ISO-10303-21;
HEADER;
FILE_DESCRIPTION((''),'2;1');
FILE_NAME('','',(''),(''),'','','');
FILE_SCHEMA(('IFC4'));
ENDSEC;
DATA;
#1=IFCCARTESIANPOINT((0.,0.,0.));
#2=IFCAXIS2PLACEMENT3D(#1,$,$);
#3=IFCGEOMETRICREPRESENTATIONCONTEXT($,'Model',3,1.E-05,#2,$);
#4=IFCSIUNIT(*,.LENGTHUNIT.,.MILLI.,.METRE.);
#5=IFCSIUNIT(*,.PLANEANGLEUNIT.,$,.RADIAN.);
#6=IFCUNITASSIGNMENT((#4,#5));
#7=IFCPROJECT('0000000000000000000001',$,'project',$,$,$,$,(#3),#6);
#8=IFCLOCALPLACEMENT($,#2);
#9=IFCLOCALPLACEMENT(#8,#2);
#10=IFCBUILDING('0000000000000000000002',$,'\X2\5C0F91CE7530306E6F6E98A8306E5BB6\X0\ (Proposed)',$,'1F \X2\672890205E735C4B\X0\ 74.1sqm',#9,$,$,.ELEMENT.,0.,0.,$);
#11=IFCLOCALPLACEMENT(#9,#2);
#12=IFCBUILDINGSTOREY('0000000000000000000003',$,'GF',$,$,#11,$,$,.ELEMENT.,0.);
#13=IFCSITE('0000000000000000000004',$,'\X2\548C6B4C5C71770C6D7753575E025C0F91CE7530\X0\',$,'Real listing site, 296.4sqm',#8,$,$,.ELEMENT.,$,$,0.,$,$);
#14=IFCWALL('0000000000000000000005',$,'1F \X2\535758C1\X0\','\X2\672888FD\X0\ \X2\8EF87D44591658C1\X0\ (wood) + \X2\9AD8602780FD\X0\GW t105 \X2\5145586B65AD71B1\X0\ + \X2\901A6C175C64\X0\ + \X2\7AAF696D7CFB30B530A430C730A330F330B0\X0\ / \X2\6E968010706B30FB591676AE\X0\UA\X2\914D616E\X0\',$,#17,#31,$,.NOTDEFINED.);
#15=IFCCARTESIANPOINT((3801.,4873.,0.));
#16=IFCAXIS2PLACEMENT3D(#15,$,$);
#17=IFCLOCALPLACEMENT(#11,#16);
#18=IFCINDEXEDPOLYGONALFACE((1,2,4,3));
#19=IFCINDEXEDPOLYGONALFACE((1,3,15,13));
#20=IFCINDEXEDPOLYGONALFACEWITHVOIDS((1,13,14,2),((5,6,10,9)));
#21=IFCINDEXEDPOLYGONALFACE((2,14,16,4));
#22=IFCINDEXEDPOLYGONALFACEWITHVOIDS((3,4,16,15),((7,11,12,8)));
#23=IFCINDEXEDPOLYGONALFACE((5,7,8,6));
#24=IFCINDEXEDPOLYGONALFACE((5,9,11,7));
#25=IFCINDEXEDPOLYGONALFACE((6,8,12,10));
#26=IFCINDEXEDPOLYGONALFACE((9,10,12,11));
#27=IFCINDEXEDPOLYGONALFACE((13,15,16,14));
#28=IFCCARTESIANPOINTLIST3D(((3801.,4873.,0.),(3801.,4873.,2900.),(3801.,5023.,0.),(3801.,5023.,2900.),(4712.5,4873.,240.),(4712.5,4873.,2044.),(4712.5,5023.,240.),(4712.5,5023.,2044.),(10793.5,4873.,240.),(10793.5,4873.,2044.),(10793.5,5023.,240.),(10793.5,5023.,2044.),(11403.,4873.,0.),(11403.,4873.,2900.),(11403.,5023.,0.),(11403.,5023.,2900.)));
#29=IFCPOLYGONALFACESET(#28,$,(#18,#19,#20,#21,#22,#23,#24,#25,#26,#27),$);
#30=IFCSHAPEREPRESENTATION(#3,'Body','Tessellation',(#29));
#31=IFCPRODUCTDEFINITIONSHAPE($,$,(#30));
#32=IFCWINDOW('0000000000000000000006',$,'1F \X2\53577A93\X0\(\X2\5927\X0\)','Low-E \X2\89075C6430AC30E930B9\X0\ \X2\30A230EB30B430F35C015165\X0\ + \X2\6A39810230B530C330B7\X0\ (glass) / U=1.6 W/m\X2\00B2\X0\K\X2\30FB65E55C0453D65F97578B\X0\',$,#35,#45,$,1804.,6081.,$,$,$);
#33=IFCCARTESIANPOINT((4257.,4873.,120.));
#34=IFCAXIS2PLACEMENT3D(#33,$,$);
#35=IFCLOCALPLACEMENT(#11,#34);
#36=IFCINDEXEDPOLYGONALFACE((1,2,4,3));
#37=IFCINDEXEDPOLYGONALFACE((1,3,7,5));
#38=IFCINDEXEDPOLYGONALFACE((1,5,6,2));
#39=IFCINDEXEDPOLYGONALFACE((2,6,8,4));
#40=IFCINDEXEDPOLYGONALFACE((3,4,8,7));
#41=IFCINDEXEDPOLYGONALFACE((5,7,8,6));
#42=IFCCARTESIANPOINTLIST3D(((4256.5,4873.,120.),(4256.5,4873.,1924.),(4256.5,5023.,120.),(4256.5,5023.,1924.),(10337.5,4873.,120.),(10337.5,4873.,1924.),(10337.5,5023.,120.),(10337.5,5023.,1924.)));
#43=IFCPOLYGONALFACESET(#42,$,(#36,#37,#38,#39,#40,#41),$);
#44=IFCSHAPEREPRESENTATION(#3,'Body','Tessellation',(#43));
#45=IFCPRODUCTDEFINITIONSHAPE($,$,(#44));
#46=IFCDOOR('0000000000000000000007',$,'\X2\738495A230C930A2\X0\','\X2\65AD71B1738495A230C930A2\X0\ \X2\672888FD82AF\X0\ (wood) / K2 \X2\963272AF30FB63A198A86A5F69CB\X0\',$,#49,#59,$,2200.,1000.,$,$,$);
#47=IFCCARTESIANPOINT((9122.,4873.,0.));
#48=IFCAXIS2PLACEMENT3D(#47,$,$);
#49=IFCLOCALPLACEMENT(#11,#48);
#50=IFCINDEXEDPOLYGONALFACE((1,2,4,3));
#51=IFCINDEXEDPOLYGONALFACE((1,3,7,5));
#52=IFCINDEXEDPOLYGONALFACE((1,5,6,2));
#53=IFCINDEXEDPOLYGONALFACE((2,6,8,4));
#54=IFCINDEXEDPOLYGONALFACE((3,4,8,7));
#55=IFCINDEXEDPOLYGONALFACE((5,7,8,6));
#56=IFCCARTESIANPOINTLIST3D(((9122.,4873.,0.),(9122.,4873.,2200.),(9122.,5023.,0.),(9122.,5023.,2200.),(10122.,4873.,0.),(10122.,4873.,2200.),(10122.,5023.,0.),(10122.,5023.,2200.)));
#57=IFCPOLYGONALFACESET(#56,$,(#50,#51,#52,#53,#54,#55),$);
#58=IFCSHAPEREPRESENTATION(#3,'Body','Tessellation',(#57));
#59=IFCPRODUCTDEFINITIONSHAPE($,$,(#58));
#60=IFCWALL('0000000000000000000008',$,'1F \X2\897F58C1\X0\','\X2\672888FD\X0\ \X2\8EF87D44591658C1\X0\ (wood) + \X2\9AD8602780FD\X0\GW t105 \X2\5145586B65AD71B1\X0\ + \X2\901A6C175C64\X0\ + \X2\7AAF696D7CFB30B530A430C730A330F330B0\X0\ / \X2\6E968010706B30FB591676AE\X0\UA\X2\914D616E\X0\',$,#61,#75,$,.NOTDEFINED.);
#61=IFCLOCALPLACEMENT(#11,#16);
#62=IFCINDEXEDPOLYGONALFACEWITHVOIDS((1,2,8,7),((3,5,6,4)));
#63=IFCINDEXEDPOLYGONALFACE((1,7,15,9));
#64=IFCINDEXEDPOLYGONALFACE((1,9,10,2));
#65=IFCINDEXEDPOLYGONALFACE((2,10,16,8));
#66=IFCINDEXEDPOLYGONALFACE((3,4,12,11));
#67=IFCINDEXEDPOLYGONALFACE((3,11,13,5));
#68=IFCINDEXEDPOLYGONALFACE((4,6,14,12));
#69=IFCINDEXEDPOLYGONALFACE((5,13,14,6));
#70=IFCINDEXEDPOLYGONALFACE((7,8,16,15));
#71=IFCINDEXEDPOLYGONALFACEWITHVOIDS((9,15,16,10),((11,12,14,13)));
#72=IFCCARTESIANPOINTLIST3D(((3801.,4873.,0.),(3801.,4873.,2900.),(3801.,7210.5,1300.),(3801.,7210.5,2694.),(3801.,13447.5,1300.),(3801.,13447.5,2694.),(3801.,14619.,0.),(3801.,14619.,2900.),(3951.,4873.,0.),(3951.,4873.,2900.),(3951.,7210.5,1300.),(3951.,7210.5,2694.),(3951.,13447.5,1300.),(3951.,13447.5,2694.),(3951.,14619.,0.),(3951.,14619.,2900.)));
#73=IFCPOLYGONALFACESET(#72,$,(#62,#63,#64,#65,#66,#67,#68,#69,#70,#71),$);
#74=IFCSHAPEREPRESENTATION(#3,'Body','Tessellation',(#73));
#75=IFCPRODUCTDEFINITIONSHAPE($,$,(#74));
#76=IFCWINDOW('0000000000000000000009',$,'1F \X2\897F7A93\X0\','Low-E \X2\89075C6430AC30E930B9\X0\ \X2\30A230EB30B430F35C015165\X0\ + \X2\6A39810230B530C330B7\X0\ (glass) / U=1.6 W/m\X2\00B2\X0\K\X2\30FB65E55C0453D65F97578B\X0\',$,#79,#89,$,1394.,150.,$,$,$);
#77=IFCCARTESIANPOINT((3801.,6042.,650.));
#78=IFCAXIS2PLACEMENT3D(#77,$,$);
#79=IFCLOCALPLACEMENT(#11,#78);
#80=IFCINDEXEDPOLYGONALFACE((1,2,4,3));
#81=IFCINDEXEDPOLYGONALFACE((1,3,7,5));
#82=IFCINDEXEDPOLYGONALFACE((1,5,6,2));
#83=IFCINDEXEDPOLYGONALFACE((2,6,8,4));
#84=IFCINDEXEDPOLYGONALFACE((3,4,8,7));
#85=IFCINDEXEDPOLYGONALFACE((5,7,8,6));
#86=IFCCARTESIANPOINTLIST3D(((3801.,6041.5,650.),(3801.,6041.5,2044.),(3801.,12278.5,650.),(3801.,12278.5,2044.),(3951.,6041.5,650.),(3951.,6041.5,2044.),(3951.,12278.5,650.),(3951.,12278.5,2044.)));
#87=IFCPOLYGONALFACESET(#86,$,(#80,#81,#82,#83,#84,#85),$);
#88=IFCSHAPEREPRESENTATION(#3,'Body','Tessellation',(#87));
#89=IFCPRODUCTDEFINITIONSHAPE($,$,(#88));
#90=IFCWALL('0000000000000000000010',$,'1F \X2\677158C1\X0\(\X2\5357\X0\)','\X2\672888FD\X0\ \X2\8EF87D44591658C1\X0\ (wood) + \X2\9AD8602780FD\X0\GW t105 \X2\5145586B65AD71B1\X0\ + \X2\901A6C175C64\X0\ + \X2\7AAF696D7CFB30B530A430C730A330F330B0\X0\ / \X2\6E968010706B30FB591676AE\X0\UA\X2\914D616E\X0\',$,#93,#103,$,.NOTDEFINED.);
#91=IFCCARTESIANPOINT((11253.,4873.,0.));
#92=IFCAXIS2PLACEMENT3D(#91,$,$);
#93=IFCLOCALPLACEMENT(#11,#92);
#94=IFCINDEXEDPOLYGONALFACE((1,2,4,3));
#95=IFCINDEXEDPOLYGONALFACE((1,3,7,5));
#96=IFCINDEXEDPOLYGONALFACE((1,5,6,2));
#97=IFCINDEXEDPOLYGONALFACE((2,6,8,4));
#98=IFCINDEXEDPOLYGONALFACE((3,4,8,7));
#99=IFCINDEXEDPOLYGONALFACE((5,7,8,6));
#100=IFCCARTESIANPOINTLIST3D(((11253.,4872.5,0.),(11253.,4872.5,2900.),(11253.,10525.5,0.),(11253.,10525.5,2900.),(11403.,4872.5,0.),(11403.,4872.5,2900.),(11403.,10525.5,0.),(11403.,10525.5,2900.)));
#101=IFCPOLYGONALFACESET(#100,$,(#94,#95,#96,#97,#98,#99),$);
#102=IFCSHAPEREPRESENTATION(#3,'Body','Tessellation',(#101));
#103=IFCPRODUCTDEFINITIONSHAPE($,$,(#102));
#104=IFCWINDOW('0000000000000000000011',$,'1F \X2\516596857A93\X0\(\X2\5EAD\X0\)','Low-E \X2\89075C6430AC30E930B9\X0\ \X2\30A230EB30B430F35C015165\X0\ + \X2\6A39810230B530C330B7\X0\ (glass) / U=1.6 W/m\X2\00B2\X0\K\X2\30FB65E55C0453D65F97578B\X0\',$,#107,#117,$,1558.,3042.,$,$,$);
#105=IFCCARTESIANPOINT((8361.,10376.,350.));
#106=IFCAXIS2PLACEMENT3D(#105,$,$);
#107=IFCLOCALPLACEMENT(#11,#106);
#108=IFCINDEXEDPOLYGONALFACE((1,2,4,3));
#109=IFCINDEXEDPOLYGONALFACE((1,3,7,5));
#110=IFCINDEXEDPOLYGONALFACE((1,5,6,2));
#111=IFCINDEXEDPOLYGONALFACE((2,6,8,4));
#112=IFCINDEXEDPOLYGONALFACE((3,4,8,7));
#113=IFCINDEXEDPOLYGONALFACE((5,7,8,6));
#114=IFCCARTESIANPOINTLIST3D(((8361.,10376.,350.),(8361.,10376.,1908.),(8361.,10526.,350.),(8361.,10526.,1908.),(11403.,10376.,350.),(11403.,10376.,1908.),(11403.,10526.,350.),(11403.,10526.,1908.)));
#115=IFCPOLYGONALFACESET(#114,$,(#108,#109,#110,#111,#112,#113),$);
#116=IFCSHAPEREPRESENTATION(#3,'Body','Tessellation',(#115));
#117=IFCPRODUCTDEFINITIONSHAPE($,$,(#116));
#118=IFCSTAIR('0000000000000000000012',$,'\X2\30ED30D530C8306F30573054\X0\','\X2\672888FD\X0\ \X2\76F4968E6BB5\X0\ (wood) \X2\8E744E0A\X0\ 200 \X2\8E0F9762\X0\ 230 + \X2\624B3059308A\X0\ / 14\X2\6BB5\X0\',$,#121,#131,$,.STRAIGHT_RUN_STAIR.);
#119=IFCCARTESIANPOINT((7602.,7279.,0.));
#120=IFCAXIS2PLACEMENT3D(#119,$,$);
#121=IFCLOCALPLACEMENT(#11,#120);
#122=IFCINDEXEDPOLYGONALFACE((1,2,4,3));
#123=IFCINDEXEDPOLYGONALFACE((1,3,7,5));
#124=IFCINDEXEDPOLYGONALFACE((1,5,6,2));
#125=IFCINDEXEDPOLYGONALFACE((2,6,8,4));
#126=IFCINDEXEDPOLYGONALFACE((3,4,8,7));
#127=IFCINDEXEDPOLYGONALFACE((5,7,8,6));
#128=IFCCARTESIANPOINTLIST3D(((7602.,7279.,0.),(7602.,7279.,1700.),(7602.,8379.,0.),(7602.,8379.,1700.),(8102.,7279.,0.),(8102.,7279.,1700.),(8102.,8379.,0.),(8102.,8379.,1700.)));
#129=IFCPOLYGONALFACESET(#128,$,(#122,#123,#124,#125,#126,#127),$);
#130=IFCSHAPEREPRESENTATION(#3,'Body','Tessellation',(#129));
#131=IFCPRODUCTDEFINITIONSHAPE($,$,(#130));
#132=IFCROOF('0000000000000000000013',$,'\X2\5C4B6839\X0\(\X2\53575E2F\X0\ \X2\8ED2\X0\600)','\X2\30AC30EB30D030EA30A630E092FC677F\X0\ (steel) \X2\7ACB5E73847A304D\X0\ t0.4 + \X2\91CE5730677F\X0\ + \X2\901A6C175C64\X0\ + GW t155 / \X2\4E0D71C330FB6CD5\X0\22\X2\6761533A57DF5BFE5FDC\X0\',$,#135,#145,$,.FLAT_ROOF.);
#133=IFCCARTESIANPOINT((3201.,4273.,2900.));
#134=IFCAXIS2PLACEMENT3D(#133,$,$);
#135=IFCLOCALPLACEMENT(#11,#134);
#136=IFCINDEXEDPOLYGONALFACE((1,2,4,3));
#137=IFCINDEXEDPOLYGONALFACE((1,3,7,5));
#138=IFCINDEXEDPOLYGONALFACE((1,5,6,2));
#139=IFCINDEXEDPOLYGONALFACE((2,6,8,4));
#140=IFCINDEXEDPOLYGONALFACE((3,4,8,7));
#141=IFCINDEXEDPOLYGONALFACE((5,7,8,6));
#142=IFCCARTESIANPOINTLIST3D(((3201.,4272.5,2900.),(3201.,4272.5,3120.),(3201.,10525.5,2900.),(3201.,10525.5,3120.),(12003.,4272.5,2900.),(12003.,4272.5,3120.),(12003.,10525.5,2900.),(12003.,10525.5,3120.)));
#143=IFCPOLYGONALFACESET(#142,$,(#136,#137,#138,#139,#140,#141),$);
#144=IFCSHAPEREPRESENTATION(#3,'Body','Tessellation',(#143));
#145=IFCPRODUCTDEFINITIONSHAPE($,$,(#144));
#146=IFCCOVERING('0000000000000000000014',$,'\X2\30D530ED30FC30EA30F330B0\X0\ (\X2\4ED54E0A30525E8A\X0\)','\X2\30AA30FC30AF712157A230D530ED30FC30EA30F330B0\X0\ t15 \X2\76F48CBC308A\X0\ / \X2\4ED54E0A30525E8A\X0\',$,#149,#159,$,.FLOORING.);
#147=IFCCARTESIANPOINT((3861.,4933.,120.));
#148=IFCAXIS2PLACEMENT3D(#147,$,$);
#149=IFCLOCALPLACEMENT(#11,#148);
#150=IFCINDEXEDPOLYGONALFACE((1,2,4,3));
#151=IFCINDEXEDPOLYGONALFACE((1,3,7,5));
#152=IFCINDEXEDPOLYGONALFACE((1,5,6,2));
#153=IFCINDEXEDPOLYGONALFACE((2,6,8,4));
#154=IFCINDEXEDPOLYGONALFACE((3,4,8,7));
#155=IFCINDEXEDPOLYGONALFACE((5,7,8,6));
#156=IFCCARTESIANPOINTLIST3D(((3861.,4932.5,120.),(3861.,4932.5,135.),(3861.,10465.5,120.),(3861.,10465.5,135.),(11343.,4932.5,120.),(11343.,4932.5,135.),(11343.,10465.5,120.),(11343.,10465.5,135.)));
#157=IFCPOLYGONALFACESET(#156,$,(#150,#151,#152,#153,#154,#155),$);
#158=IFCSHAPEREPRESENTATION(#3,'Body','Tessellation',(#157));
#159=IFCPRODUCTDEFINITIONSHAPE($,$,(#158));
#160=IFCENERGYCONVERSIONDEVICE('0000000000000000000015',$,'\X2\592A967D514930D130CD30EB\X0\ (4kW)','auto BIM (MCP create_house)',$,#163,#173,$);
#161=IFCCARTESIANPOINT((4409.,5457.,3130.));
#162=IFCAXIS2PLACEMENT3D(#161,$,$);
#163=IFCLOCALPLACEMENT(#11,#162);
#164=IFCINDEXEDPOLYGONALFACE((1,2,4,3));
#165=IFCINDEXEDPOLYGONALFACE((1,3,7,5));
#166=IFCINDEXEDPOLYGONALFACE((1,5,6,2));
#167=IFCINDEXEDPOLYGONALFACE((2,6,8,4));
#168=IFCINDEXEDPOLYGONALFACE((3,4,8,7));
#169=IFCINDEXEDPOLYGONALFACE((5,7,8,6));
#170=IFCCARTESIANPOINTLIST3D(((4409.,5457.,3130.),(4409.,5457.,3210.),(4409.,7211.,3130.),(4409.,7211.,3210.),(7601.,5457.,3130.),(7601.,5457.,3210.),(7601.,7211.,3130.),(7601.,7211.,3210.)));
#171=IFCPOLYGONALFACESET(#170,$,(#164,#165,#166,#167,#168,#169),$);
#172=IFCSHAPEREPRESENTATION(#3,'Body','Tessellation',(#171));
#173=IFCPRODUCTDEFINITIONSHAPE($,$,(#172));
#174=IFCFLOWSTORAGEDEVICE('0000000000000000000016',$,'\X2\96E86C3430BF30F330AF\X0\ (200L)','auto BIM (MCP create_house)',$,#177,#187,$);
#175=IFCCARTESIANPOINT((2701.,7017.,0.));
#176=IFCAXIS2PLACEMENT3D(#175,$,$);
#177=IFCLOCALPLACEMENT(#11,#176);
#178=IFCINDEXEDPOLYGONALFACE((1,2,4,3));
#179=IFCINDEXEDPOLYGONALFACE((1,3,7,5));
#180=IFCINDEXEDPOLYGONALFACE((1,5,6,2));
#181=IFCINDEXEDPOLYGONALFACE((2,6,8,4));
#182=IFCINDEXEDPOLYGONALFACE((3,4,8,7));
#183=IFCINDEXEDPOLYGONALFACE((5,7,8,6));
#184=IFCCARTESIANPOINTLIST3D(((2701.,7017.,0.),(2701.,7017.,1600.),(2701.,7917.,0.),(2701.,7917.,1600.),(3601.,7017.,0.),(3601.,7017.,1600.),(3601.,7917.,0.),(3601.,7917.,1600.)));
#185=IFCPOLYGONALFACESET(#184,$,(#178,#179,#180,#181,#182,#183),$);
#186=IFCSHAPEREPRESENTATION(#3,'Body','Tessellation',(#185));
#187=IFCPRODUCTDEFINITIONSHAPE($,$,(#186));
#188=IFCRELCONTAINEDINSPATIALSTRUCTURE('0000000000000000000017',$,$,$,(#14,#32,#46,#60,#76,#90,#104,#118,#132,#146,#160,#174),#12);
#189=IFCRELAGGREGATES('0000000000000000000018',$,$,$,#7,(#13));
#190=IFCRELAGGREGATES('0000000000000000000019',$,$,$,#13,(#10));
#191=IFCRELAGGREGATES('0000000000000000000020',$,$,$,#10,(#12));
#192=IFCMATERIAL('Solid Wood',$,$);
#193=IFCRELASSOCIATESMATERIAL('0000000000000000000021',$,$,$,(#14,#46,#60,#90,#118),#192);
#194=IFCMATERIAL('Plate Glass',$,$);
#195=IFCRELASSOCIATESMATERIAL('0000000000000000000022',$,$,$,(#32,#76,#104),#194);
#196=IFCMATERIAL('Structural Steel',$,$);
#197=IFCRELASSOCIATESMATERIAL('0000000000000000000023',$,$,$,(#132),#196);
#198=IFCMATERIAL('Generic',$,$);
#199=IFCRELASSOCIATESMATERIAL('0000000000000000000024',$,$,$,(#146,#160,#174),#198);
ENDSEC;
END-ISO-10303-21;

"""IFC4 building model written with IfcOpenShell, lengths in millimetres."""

from ifc_helpers import new_model, si_unit, frame, frame_2d, origin, place, context, project, spatial, rectangle, extrude, material, element, fill, save


model = new_model("IFC4")

# Units and contexts
model_context = context("Model", 3, precision=1e-05, world=origin())
ifc_project = project(units=[si_unit("LENGTHUNIT", "METRE", prefix="MILLI"), si_unit("PLANEANGLEUNIT", "RADIAN")], contexts=[model_context])

# Site, building, storey
site_placement = place(None, origin())
site = spatial("IfcSite", under=ifc_project, at=site_placement, Name="和歌山県海南市小野田", ObjectType="Real listing site, 296.4sqm", CompositionType="ELEMENT", RefElevation=0.0)
building_placement = place(site_placement, origin())
building = spatial("IfcBuilding", under=site, at=building_placement, Name="小野田の潮風の家 (Proposed)", ObjectType="1F 木造平屋 74.1sqm", CompositionType="ELEMENT", ElevationOfRefHeight=0.0, ElevationOfTerrain=0.0)
storey_placement = place(building_placement, origin())
storey = spatial("IfcBuildingStorey", under=building, at=storey_placement, Name="GF", CompositionType="ELEMENT", Elevation=0.0)

# Shared definitions
ifc_material_1 = material(Name="Solid Wood")

# Wall, openings, window, door
wall_1_placement = place(storey_placement, frame((3801.0, 4873.0, 0.0)))
wall_1 = element("IfcWall", 1, at=wall_1_placement, inside=storey, material=ifc_material_1, Name="1F 南壁", Description="木製 軸組外壁 (wood) + 高性能GW t105 充填断熱 + 通気層 + 窯業系サイディング / 準耐火・外皮UA配慮", PredefinedType="NOTDEFINED", context=model_context, shape_type="SweptSolid", body=[
    extrude(rectangle(XDim=7602.0, YDim=150.0, at=frame_2d((3801.0, 75.0))), frame((3801.0, 4873.0, 0.0)), (0.0, 0.0, 1.0), 2900.0),
])
opening_1_placement = place(storey_placement, frame((4257.0, 4873.0, 120.0)))
opening_1 = element("IfcOpeningElement", 2, at=opening_1_placement, cuts=wall_1, PredefinedType="NOTDEFINED", context=model_context, shape_type="SweptSolid", body=[
    extrude(rectangle(XDim=6081.0, YDim=150.0, at=frame_2d((3040.0, 75.0))), frame((4257.0, 4873.0, 120.0)), (0.0, 0.0, 1.0), 1804.0),
])
opening_2_placement = place(storey_placement, frame((9122.0, 4873.0, 0.0)))
opening_2 = element("IfcOpeningElement", 3, at=opening_2_placement, cuts=wall_1, PredefinedType="NOTDEFINED", context=model_context, shape_type="SweptSolid", body=[
    extrude(rectangle(XDim=1000.0, YDim=150.0, at=frame_2d((500.0, 75.0))), frame((9122.0, 4873.0, 0.0)), (0.0, 0.0, 1.0), 2200.0),
])
ifc_material_2 = material(Name="Plate Glass")
window_1_placement = place(storey_placement, frame((4257.0, 4873.0, 120.0)))
window_1 = element("IfcWindow", 4, at=window_1_placement, inside=storey, material=ifc_material_2, Name="1F 南窓(大)", Description="Low-E 複層ガラス アルゴン封入 + 樹脂サッシ (glass) / U=1.6 W/m²K・日射取得型", OverallHeight=1804.0, OverallWidth=6081.0, context=model_context, shape_type="SweptSolid", body=[
    extrude(rectangle(XDim=6081.0, YDim=150.0, at=frame_2d((3040.0, 75.0))), frame((4257.0, 4873.0, 120.0)), (0.0, 0.0, 1.0), 1804.0),
])
fill(opening_1, window_1)
door_1_placement = place(storey_placement, frame((9122.0, 4873.0, 0.0)))
door_1 = element("IfcDoor", 5, at=door_1_placement, inside=storey, material=ifc_material_1, Name="玄関ドア", Description="断熱玄関ドア 木製芯 (wood) / K2 防犯・採風機構", OverallHeight=2200.0, OverallWidth=1000.0, context=model_context, shape_type="SweptSolid", body=[
    extrude(rectangle(XDim=1000.0, YDim=150.0, at=frame_2d((500.0, 75.0))), frame((9122.0, 4873.0, 0.0)), (0.0, 0.0, 1.0), 2200.0),
])
fill(opening_2, door_1)

# Walls, openings, windows
wall_2_placement = place(storey_placement, frame((3801.0, 4873.0, 0.0)))
wall_2 = element("IfcWall", 6, at=wall_2_placement, inside=storey, material=ifc_material_1, Name="1F 西壁", Description="木製 軸組外壁 (wood) + 高性能GW t105 充填断熱 + 通気層 + 窯業系サイディング / 準耐火・外皮UA配慮", PredefinedType="NOTDEFINED", context=model_context, shape_type="SweptSolid", body=[
    extrude(rectangle(XDim=150.0, YDim=9746.0, at=frame_2d((75.0, 4873.0))), frame((3801.0, 4873.0, 0.0)), (0.0, 0.0, 1.0), 2900.0),
])
opening_3_placement = place(storey_placement, frame((3801.0, 6042.0, 650.0)))
opening_3 = element("IfcOpeningElement", 7, at=opening_3_placement, cuts=wall_2, PredefinedType="NOTDEFINED", context=model_context, shape_type="SweptSolid", body=[
    extrude(rectangle(XDim=150.0, YDim=6237.0, at=frame_2d((75.0, 3118.0))), frame((3801.0, 6042.0, 650.0)), (0.0, 0.0, 1.0), 1394.0),
])
window_2_placement = place(storey_placement, frame((3801.0, 6042.0, 650.0)))
window_2 = element("IfcWindow", 8, at=window_2_placement, inside=storey, material=ifc_material_2, Name="1F 西窓", Description="Low-E 複層ガラス アルゴン封入 + 樹脂サッシ (glass) / U=1.6 W/m²K・日射取得型", OverallHeight=1394.0, OverallWidth=150.0, context=model_context, shape_type="SweptSolid", body=[
    extrude(rectangle(XDim=150.0, YDim=6237.0, at=frame_2d((75.0, 3118.0))), frame((3801.0, 6042.0, 650.0)), (0.0, 0.0, 1.0), 1394.0),
])
fill(opening_3, window_2)
wall_3_placement = place(storey_placement, frame((11253.0, 4873.0, 0.0)))
wall_3 = element("IfcWall", 9, at=wall_3_placement, inside=storey, material=ifc_material_1, Name="1F 東壁(南)", Description="木製 軸組外壁 (wood) + 高性能GW t105 充填断熱 + 通気層 + 窯業系サイディング / 準耐火・外皮UA配慮", PredefinedType="NOTDEFINED", context=model_context, shape_type="SweptSolid", body=[
    extrude(rectangle(XDim=150.0, YDim=5653.0, at=frame_2d((75.0, 2826.0))), frame((11253.0, 4873.0, 0.0)), (0.0, 0.0, 1.0), 2900.0),
])
opening_4_placement = place(storey_placement, frame((8361.0, 10376.0, 350.0)))
opening_4 = element("IfcOpeningElement", 10, at=opening_4_placement, cuts=wall_3, PredefinedType="NOTDEFINED", context=model_context, shape_type="SweptSolid", body=[
    extrude(rectangle(XDim=3042.0, YDim=150.0, at=frame_2d((1521.0, 75.0))), frame((8361.0, 10376.0, 350.0)), (0.0, 0.0, 1.0), 1558.0),
])
window_3_placement = place(storey_placement, frame((8361.0, 10376.0, 350.0)))
window_3 = element("IfcWindow", 11, at=window_3_placement, inside=storey, material=ifc_material_2, Name="1F 入隅窓(庭)", Description="Low-E 複層ガラス アルゴン封入 + 樹脂サッシ (glass) / U=1.6 W/m²K・日射取得型", OverallHeight=1558.0, OverallWidth=3042.0, context=model_context, shape_type="SweptSolid", body=[
    extrude(rectangle(XDim=3042.0, YDim=150.0, at=frame_2d((1521.0, 75.0))), frame((8361.0, 10376.0, 350.0)), (0.0, 0.0, 1.0), 1558.0),
])
fill(opening_4, window_3)

# Stair
stair_placement = place(storey_placement, frame((7602.0, 7279.0, 0.0)))
element("IfcStair", 12, at=stair_placement, inside=storey, material=ifc_material_1, Name="ロフトはしご", Description="木製 直階段 (wood) 蹴上 200 踏面 230 + 手すり / 14段", PredefinedType="STRAIGHT_RUN_STAIR", context=model_context, shape_type="SweptSolid", body=[
    extrude(rectangle(XDim=500.0, YDim=1100.0, at=frame_2d((250.0, 550.0))), frame((7602.0, 7279.0, 0.0)), (0.0, 0.0, 1.0), 1700.0),
])

# Roof
ifc_material_3 = material(Name="Structural Steel")
roof_placement = place(storey_placement, frame((3201.0, 4273.0, 2900.0)))
element("IfcRoof", 13, at=roof_placement, inside=storey, material=ifc_material_3, Name="屋根(南帯 軒600)", Description="ガルバリウム鋼板 (steel) 立平葺き t0.4 + 野地板 + 通気層 + GW t155 / 不燃・法22条区域対応", PredefinedType="FLAT_ROOF", context=model_context, shape_type="SweptSolid", body=[
    extrude(rectangle(XDim=8802.0, YDim=6253.0, at=frame_2d((4401.0, 3126.0))), frame((3201.0, 4273.0, 2900.0)), (0.0, 0.0, 1.0), 220.0),
])

# Covering
ifc_material_4 = material(Name="Generic")
covering_placement = place(storey_placement, frame((3861.0, 4933.0, 120.0)))
element("IfcCovering", 14, at=covering_placement, inside=storey, material=ifc_material_4, Name="フローリング (仕上げ床)", Description="オーク無垢フローリング t15 直貼り / 仕上げ床", PredefinedType="FLOORING", context=model_context, shape_type="SweptSolid", body=[
    extrude(rectangle(XDim=7482.0, YDim=5533.0, at=frame_2d((3741.0, 2766.0))), frame((3861.0, 4933.0, 120.0)), (0.0, 0.0, 1.0), 15.0),
])

# Energy conversion device
energy_conversion_device_placement = place(storey_placement, frame((4409.0, 5457.0, 3130.0)))
element("IfcEnergyConversionDevice", 15, at=energy_conversion_device_placement, inside=storey, material=ifc_material_4, Name="太陽光パネル (4kW)", Description="auto BIM (MCP create_house)", context=model_context, shape_type="SweptSolid", body=[
    extrude(rectangle(XDim=3192.0, YDim=1754.0, at=frame_2d((1596.0, 877.0))), frame((4409.0, 5457.0, 3130.0)), (0.0, 0.0, 1.0), 80.0),
])

# Flow storage device
flow_storage_device_placement = place(storey_placement, frame((2701.0, 7017.0, 0.0)))
element("IfcFlowStorageDevice", 16, at=flow_storage_device_placement, inside=storey, material=ifc_material_4, Name="雨水タンク (200L)", Description="auto BIM (MCP create_house)", context=model_context, shape_type="SweptSolid", body=[
    extrude(rectangle(XDim=900.0, YDim=900.0, at=frame_2d((450.0, 450.0))), frame((2701.0, 7017.0, 0.0)), (0.0, 0.0, 1.0), 1600.0),
])

save(model, "model.ifc")
